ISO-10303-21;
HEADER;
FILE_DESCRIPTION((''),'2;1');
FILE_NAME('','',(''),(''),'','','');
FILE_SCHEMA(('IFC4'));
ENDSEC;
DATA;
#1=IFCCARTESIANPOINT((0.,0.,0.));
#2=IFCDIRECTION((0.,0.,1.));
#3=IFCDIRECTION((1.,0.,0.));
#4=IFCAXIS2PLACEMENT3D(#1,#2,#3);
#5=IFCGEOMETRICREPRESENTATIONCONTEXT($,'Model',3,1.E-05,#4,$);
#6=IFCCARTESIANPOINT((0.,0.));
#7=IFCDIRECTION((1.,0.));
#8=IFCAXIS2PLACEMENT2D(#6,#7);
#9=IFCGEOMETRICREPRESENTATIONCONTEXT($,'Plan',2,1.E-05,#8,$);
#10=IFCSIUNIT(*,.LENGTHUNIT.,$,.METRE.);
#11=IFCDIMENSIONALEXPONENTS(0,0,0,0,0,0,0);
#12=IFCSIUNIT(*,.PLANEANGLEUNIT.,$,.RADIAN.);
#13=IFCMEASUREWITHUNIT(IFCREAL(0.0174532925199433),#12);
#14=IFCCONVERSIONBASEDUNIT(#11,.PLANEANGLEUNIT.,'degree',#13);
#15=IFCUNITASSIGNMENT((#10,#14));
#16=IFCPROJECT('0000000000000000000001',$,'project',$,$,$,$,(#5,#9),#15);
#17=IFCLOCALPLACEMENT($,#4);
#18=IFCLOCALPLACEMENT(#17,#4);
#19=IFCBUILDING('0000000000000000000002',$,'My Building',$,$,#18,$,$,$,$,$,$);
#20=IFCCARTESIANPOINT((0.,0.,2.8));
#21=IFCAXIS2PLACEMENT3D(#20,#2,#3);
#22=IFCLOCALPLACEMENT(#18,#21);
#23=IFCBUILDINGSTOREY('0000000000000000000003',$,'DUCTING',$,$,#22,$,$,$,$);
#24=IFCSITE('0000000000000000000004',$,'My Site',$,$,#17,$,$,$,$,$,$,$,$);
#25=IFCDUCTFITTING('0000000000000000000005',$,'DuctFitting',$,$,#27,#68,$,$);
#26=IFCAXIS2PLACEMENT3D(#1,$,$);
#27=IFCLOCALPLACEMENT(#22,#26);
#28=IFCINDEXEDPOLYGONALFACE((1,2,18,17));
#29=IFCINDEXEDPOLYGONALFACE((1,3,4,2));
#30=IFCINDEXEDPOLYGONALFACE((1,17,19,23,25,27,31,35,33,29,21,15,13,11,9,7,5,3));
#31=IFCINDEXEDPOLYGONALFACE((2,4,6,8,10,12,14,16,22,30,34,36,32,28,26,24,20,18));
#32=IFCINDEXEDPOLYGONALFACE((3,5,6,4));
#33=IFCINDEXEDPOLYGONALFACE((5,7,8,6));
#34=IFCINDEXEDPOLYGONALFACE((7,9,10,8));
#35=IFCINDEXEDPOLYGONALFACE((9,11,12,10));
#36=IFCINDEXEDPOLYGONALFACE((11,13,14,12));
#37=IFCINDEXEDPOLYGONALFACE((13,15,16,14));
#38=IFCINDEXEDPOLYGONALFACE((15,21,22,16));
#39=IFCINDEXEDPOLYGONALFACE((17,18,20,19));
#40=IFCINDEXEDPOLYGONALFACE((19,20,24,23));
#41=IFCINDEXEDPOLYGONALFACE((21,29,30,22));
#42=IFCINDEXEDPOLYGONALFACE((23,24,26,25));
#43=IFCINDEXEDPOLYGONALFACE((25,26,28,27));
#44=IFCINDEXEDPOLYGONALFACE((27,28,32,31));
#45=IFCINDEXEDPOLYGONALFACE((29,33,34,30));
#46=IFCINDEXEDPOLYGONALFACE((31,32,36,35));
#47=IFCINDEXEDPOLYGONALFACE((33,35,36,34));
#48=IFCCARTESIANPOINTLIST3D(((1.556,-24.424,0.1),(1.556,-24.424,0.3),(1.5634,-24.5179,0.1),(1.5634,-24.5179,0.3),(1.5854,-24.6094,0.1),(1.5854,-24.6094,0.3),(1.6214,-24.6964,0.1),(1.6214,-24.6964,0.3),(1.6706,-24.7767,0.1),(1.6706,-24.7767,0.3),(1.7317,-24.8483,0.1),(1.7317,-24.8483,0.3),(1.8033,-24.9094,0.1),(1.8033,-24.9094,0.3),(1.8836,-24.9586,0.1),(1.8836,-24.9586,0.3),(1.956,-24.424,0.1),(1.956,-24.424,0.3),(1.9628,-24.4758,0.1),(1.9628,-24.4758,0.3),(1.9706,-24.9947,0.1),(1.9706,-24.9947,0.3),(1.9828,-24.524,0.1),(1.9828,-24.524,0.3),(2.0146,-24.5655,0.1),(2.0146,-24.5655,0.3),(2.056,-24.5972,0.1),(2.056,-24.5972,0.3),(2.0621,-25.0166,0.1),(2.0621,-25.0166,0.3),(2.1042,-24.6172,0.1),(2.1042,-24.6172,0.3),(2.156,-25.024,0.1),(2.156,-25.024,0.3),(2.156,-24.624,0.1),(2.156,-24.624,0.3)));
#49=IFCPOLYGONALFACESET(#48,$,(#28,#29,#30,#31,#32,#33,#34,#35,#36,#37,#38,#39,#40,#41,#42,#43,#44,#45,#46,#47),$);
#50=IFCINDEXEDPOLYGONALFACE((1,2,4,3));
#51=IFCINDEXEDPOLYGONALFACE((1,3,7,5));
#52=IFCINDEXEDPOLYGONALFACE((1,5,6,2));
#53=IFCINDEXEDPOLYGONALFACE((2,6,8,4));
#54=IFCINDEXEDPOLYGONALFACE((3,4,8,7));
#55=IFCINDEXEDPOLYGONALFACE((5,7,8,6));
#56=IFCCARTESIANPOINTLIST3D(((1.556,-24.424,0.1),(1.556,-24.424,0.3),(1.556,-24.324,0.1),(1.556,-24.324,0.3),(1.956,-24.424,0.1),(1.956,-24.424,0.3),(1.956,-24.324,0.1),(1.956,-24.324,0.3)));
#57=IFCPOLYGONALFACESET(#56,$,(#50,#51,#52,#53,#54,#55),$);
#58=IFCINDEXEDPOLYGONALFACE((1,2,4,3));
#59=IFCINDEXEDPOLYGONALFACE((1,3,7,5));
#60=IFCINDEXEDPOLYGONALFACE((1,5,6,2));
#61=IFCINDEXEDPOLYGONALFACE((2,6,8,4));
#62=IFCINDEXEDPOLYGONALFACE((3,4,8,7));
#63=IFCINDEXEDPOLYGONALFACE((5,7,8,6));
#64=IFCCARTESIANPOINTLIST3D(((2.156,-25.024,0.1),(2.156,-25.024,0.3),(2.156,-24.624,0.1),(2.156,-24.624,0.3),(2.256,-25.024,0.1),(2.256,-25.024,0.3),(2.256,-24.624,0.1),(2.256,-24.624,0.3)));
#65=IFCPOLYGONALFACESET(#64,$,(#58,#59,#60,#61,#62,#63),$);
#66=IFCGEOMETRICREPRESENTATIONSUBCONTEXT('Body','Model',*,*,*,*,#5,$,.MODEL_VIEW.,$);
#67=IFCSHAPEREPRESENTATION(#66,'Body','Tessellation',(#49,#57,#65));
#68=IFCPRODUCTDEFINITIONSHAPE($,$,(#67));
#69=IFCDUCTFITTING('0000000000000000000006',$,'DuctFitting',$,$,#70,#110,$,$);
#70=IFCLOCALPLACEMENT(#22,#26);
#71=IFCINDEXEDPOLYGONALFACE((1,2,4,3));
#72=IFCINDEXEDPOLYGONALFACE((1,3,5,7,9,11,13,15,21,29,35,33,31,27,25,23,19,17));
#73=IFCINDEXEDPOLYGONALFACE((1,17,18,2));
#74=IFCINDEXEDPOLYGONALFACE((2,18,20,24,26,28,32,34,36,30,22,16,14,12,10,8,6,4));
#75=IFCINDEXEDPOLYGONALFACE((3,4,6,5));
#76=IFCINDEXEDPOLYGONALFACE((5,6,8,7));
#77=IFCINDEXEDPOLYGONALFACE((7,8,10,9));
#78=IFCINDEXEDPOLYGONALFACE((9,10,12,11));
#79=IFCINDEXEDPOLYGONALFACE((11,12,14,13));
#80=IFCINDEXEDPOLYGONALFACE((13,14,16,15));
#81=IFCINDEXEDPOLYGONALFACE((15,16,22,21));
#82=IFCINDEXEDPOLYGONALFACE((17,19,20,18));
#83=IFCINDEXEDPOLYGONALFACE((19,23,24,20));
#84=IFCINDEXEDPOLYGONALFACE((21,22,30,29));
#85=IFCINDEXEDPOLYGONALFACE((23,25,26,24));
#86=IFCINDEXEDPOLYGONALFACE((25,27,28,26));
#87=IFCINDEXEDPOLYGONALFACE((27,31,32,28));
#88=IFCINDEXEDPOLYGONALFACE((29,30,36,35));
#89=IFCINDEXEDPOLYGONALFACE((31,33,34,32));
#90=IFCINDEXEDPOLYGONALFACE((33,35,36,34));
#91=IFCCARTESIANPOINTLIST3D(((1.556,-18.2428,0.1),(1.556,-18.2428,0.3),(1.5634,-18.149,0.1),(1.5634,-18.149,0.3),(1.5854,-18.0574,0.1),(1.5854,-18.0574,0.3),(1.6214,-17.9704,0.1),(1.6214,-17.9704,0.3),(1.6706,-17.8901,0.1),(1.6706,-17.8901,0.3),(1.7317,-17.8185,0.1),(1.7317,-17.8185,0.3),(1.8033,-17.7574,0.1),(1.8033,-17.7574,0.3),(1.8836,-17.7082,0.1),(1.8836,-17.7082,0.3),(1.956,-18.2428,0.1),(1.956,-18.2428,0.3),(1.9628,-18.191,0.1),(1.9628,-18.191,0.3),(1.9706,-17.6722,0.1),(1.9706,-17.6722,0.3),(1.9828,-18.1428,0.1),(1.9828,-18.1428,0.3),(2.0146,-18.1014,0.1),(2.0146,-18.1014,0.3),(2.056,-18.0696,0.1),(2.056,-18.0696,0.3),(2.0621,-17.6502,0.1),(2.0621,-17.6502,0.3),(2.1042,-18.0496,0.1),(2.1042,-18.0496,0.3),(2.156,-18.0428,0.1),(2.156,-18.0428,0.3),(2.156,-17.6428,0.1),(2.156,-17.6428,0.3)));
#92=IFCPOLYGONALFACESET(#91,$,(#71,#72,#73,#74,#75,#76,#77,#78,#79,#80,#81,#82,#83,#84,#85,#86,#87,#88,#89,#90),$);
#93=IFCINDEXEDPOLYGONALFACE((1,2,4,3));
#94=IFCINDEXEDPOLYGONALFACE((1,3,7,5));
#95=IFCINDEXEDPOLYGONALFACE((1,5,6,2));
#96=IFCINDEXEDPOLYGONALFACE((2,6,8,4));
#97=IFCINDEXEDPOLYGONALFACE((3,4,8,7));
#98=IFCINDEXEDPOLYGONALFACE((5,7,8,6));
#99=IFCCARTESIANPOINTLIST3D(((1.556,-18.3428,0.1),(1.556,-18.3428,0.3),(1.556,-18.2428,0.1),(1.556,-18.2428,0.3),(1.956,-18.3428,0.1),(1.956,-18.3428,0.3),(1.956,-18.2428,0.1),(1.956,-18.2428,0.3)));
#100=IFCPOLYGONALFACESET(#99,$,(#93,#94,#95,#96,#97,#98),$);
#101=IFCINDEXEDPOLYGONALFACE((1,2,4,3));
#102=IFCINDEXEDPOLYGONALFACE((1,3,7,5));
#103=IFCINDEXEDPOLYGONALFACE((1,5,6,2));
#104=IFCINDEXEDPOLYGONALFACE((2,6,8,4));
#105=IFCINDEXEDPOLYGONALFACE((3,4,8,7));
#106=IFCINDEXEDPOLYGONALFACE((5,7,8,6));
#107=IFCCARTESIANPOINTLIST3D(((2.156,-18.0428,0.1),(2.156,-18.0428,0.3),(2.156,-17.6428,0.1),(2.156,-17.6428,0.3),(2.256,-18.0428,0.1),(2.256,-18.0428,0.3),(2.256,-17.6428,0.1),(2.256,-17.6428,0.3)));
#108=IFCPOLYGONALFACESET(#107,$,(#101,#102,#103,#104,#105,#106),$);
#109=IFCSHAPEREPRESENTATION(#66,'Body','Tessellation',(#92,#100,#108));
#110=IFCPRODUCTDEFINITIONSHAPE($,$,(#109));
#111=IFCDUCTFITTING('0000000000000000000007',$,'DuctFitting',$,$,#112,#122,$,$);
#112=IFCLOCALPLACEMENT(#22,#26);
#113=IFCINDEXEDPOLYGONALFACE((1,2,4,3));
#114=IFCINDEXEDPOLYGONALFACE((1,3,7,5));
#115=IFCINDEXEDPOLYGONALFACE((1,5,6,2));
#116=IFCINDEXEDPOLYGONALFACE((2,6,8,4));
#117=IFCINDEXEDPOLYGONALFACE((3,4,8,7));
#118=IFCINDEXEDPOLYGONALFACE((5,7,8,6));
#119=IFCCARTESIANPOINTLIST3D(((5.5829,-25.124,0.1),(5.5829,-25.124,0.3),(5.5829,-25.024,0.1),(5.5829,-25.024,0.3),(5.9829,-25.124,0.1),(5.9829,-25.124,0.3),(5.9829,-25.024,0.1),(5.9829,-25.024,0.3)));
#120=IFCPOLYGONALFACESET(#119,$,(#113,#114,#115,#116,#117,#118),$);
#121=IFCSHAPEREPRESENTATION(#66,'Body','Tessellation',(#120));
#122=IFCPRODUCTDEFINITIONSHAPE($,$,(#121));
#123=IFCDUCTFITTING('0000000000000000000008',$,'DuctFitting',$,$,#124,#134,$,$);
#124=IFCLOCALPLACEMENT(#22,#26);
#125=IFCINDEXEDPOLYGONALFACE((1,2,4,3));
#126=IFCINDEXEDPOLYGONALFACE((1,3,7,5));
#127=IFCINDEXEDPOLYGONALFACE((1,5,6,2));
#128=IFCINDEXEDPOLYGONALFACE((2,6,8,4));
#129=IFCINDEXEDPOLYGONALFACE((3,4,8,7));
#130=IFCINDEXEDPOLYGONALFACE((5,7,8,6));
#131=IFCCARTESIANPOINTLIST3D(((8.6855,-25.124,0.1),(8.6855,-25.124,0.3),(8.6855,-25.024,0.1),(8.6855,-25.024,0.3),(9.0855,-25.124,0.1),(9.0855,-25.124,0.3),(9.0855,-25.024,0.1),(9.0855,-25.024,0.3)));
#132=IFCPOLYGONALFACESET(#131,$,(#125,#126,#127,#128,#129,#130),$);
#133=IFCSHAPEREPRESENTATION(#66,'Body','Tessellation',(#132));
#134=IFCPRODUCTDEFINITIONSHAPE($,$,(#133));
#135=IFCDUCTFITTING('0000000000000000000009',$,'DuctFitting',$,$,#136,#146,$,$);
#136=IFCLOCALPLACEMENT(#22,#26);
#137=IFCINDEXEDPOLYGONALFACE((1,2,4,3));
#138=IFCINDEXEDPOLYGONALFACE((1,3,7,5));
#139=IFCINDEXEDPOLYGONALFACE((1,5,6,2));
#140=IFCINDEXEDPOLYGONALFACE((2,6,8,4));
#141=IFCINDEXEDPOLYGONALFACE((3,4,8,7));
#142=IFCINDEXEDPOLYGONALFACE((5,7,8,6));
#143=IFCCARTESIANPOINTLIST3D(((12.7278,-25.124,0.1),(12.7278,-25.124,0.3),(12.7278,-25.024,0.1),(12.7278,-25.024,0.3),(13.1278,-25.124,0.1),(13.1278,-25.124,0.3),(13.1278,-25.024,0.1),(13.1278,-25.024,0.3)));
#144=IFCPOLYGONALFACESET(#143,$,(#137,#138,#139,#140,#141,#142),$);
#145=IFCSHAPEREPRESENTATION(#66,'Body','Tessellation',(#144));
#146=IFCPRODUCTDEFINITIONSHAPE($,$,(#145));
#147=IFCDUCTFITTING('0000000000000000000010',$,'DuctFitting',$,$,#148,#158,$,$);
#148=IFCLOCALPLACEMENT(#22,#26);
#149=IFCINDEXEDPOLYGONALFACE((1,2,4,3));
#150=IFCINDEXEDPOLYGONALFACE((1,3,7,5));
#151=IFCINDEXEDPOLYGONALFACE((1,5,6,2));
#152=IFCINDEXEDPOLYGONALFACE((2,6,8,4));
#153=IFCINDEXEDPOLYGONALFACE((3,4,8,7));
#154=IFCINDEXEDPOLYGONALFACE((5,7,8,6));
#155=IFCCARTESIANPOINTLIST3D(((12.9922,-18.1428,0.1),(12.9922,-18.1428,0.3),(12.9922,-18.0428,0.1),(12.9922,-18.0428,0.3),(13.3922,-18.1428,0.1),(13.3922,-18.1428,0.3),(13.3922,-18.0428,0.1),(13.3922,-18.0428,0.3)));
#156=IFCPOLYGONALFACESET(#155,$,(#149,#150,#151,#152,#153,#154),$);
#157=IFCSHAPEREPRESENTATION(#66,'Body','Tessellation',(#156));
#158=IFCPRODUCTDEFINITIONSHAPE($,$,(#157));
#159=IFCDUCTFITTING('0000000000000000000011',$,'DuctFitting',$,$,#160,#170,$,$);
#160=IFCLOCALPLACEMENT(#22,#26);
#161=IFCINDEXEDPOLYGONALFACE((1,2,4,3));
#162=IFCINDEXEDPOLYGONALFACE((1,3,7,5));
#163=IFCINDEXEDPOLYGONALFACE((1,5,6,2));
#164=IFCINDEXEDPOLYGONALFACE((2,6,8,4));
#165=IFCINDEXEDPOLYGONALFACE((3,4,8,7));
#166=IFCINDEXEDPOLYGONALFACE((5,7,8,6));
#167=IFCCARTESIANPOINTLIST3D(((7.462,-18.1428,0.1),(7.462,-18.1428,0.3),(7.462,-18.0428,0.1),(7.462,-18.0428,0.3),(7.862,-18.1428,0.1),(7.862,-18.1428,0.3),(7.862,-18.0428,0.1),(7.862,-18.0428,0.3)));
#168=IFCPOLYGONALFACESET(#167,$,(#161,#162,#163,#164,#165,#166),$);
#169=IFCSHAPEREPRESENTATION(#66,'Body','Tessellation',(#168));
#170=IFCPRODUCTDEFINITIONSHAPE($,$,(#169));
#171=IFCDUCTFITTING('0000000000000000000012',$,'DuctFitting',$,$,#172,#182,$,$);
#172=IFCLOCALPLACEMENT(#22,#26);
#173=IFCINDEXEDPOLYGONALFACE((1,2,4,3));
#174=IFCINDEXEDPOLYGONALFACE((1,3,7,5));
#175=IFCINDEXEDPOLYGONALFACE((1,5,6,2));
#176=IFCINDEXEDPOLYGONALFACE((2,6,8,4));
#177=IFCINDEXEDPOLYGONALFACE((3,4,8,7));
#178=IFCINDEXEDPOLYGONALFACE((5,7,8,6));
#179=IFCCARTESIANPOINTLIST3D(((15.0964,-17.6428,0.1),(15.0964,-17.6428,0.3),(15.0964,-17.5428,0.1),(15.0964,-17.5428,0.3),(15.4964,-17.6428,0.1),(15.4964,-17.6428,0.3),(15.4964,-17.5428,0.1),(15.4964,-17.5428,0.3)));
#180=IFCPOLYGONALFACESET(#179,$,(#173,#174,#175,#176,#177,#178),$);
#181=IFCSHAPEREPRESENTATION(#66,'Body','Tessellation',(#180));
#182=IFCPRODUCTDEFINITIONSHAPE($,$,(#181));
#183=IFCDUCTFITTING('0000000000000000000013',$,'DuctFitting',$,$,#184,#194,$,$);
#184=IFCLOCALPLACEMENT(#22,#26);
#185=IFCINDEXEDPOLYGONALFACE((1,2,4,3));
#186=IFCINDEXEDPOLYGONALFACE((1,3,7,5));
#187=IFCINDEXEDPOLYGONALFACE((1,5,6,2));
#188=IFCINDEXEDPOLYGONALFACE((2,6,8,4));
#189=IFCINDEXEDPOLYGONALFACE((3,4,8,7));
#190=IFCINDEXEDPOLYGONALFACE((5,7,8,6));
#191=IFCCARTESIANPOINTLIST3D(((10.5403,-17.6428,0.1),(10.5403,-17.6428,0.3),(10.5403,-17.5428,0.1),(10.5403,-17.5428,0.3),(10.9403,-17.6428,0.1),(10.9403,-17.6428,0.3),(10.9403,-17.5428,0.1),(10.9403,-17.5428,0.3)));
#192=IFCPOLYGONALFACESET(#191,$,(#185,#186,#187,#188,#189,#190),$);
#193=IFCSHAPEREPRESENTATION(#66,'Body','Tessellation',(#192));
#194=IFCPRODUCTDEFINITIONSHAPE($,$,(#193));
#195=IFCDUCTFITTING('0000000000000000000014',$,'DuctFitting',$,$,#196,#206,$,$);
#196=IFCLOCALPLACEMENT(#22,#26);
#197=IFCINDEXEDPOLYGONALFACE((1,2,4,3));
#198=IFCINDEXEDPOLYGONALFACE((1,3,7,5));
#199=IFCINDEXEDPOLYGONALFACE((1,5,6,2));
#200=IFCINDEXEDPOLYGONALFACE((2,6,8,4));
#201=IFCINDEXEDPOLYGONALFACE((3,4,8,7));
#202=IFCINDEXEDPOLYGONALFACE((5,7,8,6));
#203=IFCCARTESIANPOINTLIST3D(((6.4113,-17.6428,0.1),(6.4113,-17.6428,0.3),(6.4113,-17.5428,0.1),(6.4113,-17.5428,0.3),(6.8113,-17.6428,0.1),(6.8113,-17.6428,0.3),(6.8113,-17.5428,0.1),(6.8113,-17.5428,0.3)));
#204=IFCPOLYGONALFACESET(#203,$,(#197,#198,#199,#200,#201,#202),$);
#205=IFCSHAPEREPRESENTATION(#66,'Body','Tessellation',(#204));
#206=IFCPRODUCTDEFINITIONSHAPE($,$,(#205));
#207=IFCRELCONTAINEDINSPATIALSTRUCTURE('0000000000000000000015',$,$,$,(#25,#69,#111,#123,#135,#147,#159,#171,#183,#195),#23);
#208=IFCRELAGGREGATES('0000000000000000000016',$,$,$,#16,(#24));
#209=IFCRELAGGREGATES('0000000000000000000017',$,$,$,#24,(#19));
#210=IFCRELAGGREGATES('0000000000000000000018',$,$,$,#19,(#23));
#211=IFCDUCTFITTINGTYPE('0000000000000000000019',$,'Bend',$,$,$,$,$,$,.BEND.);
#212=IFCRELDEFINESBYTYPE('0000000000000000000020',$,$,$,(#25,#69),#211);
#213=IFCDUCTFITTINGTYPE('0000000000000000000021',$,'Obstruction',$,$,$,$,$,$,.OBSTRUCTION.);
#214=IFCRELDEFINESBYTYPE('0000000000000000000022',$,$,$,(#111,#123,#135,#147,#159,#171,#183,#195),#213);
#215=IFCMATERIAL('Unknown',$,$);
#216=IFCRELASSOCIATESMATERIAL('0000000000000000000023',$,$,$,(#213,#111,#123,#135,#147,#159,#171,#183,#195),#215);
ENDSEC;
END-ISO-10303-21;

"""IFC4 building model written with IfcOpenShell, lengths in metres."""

from ifc_helpers import new_model, entity, si_unit, converted_unit, frame, origin_with_axes, origin_2d_with_axis, place, context, subcontext, project, spatial, line, arc, indexed_curve, rectangle, outline, extrude, source, transform, mapped, material, material_profile, profile_set, profile_usage, type_object, type_shapes, element, save


model = new_model("IFC4")

# Units and contexts
model_context = context("Model", 3, precision=1e-05, world=origin_with_axes())
plan_context = context("Plan", 2, precision=1e-05, world=origin_2d_with_axis())
body_context = subcontext(model_context, "Body", "Model", "MODEL_VIEW")
ifc_project = project(units=[si_unit("LENGTHUNIT", "METRE"), converted_unit("PLANEANGLEUNIT", "degree", entity("IfcReal", 0.0174532925199433), si_unit("PLANEANGLEUNIT", "RADIAN"), dimensions=[0, 0, 0, 0, 0, 0, 0])], contexts=[model_context, plan_context])

# Site, building, storey
site_placement = place(None, origin_with_axes())
site = spatial("IfcSite", under=ifc_project, at=site_placement, Name="My Site")
building_placement = place(site_placement, origin_with_axes())
building = spatial("IfcBuilding", under=site, at=building_placement, Name="My Building")
storey_placement = place(building_placement, frame((0.0, 0.0, 2.8), z_axis=(0.0, 0.0, 1.0), x_axis=(1.0, 0.0, 0.0)))
storey = spatial("IfcBuildingStorey", under=building, at=storey_placement, Name="DUCTING")

# Shared definitions
ifc_material = material(Name="Unknown")

# Duct fittings
duct_fitting_type_1 = type_object("IfcDuctFittingType", Name="Bend", PredefinedType="BEND")
shared_shape = source(origin_with_axes(), body_context, "Body", "SweptSolid", [
    extrude(outline(indexed_curve([(0.2, 0.0), (0.2586, 0.1414), (0.4, 0.2), (0.4, 0.6), (-0.0243, 0.4243), (-0.2, 0.0)], segments=[arc(1, 2, 3), line(3, 4), arc(4, 5, 6), line(6, 1)])), frame((0.0, -0.1, 0.1), z_axis=(0.0, -1.0, 0.0), x_axis=(1.0, 0.0, 0.0)), (0.0, 0.0, -1.0), 0.2),
    extrude(rectangle(XDim=0.4, YDim=0.2), origin_with_axes(), (0.0, 0.0, 1.0), 0.1),
    extrude(rectangle(XDim=0.4, YDim=0.2), frame((0.4, 0.0, 0.5), z_axis=(1.0, 0.0, 0.0), x_axis=(0.0, 0.0, 1.0)), (0.0, 0.0, 1.0), 0.1),
])
type_shapes(duct_fitting_type_1, [shared_shape])
for number, where, z_axis, x_axis, name in (
    (1, (1.756, -24.324, 0.2), (0.0, -1.0, 0.0), (1.0, 0.0, 0.0), "DuctFitting"),
    (2, (1.756, -18.3428, 0.2), (0.0, 1.0, 0.0), (1.0, 0.0, 0.0), "DuctFitting"),
):
    element("IfcDuctFitting", number, at=place(storey_placement, frame(where, z_axis=z_axis, x_axis=x_axis)), inside=storey, type_object=duct_fitting_type_1, Name=name, context=body_context, shape_type="MappedRepresentation", body=[
        mapped(shared_shape, transform((0.0, 0.0, 0.0), x_axis=(1.0, 0.0, 0.0), y_axis=(0.0, 1.0, 0.0), z_axis=(0.0, 0.0, 1.0), scale=1.0)),
    ])
ifc_material_profile_1 = material_profile(ifc_material, rectangle(XDim=0.4, YDim=0.2))
ifc_profile_set_1 = profile_set([ifc_material_profile_1])
ifc_profile_usage_1 = profile_usage(ifc_profile_set_1, cardinal=5)
duct_fitting_type_2 = type_object("IfcDuctFittingType", Name="Obstruction", PredefinedType="OBSTRUCTION", material=ifc_profile_set_1)
duct_fitting_1_placement = place(storey_placement, frame((5.7829, -25.124, 0.2), z_axis=(0.0, 1.0, 0.0), x_axis=(-1.0, 0.0, 0.0)))
element("IfcDuctFitting", 3, at=duct_fitting_1_placement, inside=storey, type_object=duct_fitting_type_2, material=ifc_profile_usage_1, Name="DuctFitting", context=body_context, shape_type="SweptSolid", body=[
    extrude(rectangle(XDim=0.4, YDim=0.2), origin_with_axes(), (0.0, 0.0, 1.0), 0.1),
])
ifc_profile_usage_2 = profile_usage(ifc_profile_set_1, cardinal=5)
duct_fitting_2_placement = place(storey_placement, frame((8.8855, -25.024, 0.2), z_axis=(0.0, -1.0, 0.0), x_axis=(1.0, 0.0, 0.0)))
element("IfcDuctFitting", 4, at=duct_fitting_2_placement, inside=storey, type_object=duct_fitting_type_2, material=ifc_profile_usage_2, Name="DuctFitting", context=body_context, shape_type="SweptSolid", body=[
    extrude(rectangle(XDim=0.4, YDim=0.2), origin_with_axes(), (0.0, 0.0, 1.0), 0.1),
])
ifc_profile_usage_3 = profile_usage(ifc_profile_set_1, cardinal=5)
duct_fitting_3_placement = place(storey_placement, frame((12.9278, -25.024, 0.2), z_axis=(0.0, -1.0, 0.0), x_axis=(1.0, 0.0, 0.0)))
element("IfcDuctFitting", 5, at=duct_fitting_3_placement, inside=storey, type_object=duct_fitting_type_2, material=ifc_profile_usage_3, Name="DuctFitting", context=body_context, shape_type="SweptSolid", body=[
    extrude(rectangle(XDim=0.4, YDim=0.2), origin_with_axes(), (0.0, 0.0, 1.0), 0.1),
])
ifc_profile_usage_4 = profile_usage(ifc_profile_set_1, cardinal=5)
duct_fitting_4_placement = place(storey_placement, frame((13.1922, -18.0428, 0.2), z_axis=(0.0, -1.0, 0.0), x_axis=(1.0, 0.0, 0.0)))
element("IfcDuctFitting", 6, at=duct_fitting_4_placement, inside=storey, type_object=duct_fitting_type_2, material=ifc_profile_usage_4, Name="DuctFitting", context=body_context, shape_type="SweptSolid", body=[
    extrude(rectangle(XDim=0.4, YDim=0.2), origin_with_axes(), (0.0, 0.0, 1.0), 0.1),
])
ifc_profile_usage_5 = profile_usage(ifc_profile_set_1, cardinal=5)
duct_fitting_5_placement = place(storey_placement, frame((7.662, -18.0428, 0.2), z_axis=(0.0, -1.0, 0.0), x_axis=(1.0, 0.0, 0.0)))
element("IfcDuctFitting", 7, at=duct_fitting_5_placement, inside=storey, type_object=duct_fitting_type_2, material=ifc_profile_usage_5, Name="DuctFitting", context=body_context, shape_type="SweptSolid", body=[
    extrude(rectangle(XDim=0.4, YDim=0.2), origin_with_axes(), (0.0, 0.0, 1.0), 0.1),
])
ifc_profile_usage_6 = profile_usage(ifc_profile_set_1, cardinal=5)
duct_fitting_6_placement = place(storey_placement, frame((15.2964, -17.6428, 0.2), z_axis=(0.0, 1.0, 0.0), x_axis=(-1.0, 0.0, 0.0)))
element("IfcDuctFitting", 8, at=duct_fitting_6_placement, inside=storey, type_object=duct_fitting_type_2, material=ifc_profile_usage_6, Name="DuctFitting", context=body_context, shape_type="SweptSolid", body=[
    extrude(rectangle(XDim=0.4, YDim=0.2), origin_with_axes(), (0.0, 0.0, 1.0), 0.1),
])
ifc_profile_usage_7 = profile_usage(ifc_profile_set_1, cardinal=5)
duct_fitting_7_placement = place(storey_placement, frame((10.7403, -17.6428, 0.2), z_axis=(0.0, 1.0, 0.0), x_axis=(-1.0, 0.0, 0.0)))
element("IfcDuctFitting", 9, at=duct_fitting_7_placement, inside=storey, type_object=duct_fitting_type_2, material=ifc_profile_usage_7, Name="DuctFitting", context=body_context, shape_type="SweptSolid", body=[
    extrude(rectangle(XDim=0.4, YDim=0.2), origin_with_axes(), (0.0, 0.0, 1.0), 0.1),
])
ifc_profile_usage_8 = profile_usage(ifc_profile_set_1, cardinal=5)
duct_fitting_8_placement = place(storey_placement, frame((6.6113, -17.6428, 0.2), z_axis=(0.0, 1.0, 0.0), x_axis=(-1.0, 0.0, 0.0)))
element("IfcDuctFitting", 10, at=duct_fitting_8_placement, inside=storey, type_object=duct_fitting_type_2, material=ifc_profile_usage_8, Name="DuctFitting", context=body_context, shape_type="SweptSolid", body=[
    extrude(rectangle(XDim=0.4, YDim=0.2), origin_with_axes(), (0.0, 0.0, 1.0), 0.1),
])

save(model, "model.ifc")
